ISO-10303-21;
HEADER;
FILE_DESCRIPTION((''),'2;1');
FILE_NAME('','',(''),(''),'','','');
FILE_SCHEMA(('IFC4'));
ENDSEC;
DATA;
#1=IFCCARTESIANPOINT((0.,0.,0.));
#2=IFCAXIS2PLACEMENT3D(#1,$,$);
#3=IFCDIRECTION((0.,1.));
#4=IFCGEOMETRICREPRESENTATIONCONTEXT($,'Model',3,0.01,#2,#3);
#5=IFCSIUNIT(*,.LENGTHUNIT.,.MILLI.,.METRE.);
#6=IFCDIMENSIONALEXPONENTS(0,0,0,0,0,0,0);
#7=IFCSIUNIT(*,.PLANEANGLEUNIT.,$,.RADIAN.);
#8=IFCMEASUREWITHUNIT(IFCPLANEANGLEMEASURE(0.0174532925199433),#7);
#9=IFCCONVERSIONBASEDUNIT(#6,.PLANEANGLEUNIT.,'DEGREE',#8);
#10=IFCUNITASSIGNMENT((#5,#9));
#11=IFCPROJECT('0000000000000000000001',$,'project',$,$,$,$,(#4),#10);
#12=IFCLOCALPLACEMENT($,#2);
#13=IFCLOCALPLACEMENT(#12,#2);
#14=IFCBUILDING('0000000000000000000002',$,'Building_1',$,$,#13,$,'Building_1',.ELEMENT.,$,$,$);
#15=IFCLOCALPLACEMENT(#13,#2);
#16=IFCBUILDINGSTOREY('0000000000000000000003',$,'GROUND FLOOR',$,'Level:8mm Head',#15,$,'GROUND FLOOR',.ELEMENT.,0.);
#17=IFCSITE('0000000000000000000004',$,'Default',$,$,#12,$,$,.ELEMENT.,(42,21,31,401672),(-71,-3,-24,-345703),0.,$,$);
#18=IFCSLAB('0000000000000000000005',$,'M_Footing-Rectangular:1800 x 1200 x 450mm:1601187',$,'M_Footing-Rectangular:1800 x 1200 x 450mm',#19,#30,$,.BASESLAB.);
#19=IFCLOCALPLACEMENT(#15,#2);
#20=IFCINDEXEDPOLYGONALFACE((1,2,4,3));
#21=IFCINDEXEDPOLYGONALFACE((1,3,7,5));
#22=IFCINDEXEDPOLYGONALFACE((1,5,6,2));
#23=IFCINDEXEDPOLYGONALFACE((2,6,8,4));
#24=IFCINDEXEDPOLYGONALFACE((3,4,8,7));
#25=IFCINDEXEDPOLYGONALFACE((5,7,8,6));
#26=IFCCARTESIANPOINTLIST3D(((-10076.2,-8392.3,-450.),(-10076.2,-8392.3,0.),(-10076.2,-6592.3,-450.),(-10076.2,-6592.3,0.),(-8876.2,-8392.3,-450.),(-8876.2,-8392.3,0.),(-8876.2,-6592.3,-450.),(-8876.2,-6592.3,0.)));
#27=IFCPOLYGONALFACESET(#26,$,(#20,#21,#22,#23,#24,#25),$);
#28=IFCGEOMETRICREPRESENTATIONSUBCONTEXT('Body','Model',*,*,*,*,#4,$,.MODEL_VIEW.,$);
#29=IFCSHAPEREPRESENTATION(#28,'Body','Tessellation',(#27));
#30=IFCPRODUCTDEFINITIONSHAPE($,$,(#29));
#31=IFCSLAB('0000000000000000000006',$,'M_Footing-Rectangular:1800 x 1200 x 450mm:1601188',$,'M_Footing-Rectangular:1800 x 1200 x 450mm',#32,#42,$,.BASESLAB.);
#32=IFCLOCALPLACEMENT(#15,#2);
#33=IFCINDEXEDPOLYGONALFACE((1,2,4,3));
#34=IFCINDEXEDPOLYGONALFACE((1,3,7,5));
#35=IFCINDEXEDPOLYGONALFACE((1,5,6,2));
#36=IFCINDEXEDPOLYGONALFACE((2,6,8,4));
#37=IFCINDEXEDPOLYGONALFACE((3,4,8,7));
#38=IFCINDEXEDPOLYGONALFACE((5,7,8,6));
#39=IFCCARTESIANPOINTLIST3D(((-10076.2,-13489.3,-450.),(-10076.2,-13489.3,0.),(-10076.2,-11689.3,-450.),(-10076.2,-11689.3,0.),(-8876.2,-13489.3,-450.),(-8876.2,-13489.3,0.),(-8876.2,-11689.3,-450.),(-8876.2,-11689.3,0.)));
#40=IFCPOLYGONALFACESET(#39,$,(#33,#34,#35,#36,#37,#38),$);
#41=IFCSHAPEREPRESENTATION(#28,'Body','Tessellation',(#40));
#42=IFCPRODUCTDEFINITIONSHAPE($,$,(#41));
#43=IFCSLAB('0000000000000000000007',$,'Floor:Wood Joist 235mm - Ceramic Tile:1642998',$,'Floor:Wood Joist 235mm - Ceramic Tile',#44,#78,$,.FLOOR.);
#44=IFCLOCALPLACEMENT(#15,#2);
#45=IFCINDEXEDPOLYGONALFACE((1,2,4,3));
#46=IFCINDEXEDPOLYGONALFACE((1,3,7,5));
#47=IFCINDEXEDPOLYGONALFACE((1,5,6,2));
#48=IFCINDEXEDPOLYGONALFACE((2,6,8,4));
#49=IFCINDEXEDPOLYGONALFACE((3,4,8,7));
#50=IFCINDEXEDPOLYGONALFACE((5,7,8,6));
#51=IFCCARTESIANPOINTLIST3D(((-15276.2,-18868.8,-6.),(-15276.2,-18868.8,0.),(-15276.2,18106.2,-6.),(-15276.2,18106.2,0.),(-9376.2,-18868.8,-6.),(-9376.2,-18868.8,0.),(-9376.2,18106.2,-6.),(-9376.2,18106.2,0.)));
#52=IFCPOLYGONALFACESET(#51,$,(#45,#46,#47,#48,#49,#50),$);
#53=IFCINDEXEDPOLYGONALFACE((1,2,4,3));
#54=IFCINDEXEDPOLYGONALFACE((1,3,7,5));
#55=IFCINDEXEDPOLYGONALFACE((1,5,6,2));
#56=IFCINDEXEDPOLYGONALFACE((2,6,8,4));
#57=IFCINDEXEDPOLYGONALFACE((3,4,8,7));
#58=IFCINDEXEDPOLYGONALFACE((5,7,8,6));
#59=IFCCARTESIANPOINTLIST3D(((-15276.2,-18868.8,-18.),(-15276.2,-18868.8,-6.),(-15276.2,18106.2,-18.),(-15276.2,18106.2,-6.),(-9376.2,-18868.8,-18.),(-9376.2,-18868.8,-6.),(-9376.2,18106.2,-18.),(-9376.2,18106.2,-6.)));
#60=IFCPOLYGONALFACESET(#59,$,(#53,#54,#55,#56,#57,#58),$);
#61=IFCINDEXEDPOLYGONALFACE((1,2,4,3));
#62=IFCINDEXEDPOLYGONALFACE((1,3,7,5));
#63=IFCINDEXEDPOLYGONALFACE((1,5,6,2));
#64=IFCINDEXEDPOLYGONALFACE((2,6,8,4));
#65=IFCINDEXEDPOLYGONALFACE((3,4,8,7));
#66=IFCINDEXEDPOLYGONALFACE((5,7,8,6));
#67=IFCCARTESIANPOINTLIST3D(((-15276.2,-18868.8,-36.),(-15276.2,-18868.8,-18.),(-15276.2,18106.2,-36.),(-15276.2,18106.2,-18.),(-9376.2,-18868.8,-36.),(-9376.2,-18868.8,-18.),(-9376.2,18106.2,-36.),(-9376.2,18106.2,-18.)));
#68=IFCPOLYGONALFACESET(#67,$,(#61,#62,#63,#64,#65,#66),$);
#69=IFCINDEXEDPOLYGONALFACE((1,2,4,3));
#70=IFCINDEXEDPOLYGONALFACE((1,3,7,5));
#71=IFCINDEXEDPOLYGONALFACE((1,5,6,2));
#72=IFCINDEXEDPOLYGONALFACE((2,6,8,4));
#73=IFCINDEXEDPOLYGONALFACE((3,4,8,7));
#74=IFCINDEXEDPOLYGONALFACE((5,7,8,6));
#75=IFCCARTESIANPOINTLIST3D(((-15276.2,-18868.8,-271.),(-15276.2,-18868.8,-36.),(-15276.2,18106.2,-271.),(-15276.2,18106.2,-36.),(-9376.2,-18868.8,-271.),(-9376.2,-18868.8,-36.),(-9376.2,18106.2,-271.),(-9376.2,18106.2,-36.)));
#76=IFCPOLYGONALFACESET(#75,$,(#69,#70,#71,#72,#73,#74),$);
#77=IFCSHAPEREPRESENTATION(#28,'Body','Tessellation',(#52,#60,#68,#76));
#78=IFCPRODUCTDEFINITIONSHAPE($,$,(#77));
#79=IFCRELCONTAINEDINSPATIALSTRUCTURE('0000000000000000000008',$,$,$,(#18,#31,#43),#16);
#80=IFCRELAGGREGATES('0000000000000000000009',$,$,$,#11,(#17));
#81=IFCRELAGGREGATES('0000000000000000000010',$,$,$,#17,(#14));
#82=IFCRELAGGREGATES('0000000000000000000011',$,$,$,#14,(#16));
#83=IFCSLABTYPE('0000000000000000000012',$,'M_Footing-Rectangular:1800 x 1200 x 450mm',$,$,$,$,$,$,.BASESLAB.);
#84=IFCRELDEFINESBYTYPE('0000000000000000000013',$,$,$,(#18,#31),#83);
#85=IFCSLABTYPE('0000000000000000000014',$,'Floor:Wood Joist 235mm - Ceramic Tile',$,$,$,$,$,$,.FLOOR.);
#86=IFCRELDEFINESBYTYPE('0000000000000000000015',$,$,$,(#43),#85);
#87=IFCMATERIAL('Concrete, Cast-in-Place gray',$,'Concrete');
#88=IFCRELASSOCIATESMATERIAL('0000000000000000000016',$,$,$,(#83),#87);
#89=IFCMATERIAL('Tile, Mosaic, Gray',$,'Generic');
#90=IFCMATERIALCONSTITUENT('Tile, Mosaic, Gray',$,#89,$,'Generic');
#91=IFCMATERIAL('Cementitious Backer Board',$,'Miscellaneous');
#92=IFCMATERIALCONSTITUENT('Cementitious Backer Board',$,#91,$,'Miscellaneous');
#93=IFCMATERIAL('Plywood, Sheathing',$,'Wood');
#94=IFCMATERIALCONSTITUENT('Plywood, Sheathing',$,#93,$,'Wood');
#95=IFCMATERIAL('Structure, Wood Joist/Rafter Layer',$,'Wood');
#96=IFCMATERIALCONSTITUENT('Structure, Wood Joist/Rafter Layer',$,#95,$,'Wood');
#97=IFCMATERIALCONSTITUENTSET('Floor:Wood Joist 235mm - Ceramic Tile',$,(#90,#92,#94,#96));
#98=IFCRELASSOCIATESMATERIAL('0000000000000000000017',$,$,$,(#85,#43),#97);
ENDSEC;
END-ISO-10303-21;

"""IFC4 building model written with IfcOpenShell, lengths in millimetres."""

from ifc_helpers import new_model, entity, si_unit, converted_unit, direction, frame, origin, place, context, subcontext, project, spatial, indexed_curve, outline, extrude, material, constituent, constituent_set, type_object, element, save


model = new_model("IFC4")

# Units and contexts
model_context = context("Model", 3, precision=0.01, world=origin(), true_north=direction((0.0, 1.0)))
body_context = subcontext(model_context, "Body", "Model", "MODEL_VIEW")
ifc_project = project(units=[si_unit("LENGTHUNIT", "METRE", prefix="MILLI"), converted_unit("PLANEANGLEUNIT", "DEGREE", entity("IfcPlaneAngleMeasure", 0.0174532925199433), si_unit("PLANEANGLEUNIT", "RADIAN"), dimensions=[0, 0, 0, 0, 0, 0, 0])], contexts=[model_context])

# Site, building, storey
site_placement = place(None, origin())
site = spatial("IfcSite", under=ifc_project, at=site_placement, Name="Default", CompositionType="ELEMENT", RefLatitude=(42, 21, 31, 401672), RefLongitude=(-71, -3, -24, -345703), RefElevation=0.0)
building_placement = place(site_placement, origin())
building = spatial("IfcBuilding", under=site, at=building_placement, Name="Building_1", LongName="Building_1", CompositionType="ELEMENT")
storey_placement = place(building_placement, origin())
storey = spatial("IfcBuildingStorey", under=building, at=storey_placement, Name="GROUND FLOOR", ObjectType="Level:8mm Head", LongName="GROUND FLOOR", CompositionType="ELEMENT", Elevation=0.0)

# Shared definitions
ifc_material_1 = material(Name="Concrete, Cast-in-Place gray", Category="Concrete")

# Slabs
slab_type_1 = type_object("IfcSlabType", Name="M_Footing-Rectangular:1800 x 1200 x 450mm", PredefinedType="BASESLAB", material=ifc_material_1)
slab_1_placement = place(storey_placement, origin())
element("IfcSlab", 1, at=slab_1_placement, inside=storey, type_object=slab_type_1, Name="M_Footing-Rectangular:1800 x 1200 x 450mm:1601187", ObjectType="M_Footing-Rectangular:1800 x 1200 x 450mm", PredefinedType="BASESLAB", context=body_context, shape_type="SweptSolid", body=[
    extrude(outline(indexed_curve([(-600.0, -900.0), (600.0, -900.0), (600.0, 900.0), (-600.0, 900.0), (-600.0, -900.0)], self_intersect=False)), frame((-9476.2, -7492.3, -450.0), z_axis=(0.0, 0.0, 1.0), x_axis=(-1.0, 0.0, 0.0)), (0.0, 0.0, 1.0), 450.0),
])
slab_2_placement = place(storey_placement, origin())
element("IfcSlab", 2, at=slab_2_placement, inside=storey, type_object=slab_type_1, Name="M_Footing-Rectangular:1800 x 1200 x 450mm:1601188", ObjectType="M_Footing-Rectangular:1800 x 1200 x 450mm", PredefinedType="BASESLAB", context=body_context, shape_type="SweptSolid", body=[
    extrude(outline(indexed_curve([(-600.0, -900.0), (600.0, -900.0), (600.0, 900.0), (-600.0, 900.0), (-600.0, -900.0)], self_intersect=False)), frame((-9476.2, -12589.3, -450.0), z_axis=(0.0, 0.0, 1.0), x_axis=(-1.0, 0.0, 0.0)), (0.0, 0.0, 1.0), 450.0),
])
ifc_material_2 = material(Name="Tile, Mosaic, Gray", Category="Generic")
ifc_constituent_1 = constituent(ifc_material_2, Name="Tile, Mosaic, Gray", Category="Generic")
ifc_material_3 = material(Name="Cementitious Backer Board", Category="Miscellaneous")
ifc_constituent_2 = constituent(ifc_material_3, Name="Cementitious Backer Board", Category="Miscellaneous")
ifc_material_4 = material(Name="Plywood, Sheathing", Category="Wood")
ifc_constituent_3 = constituent(ifc_material_4, Name="Plywood, Sheathing", Category="Wood")
ifc_material_5 = material(Name="Structure, Wood Joist/Rafter Layer", Category="Wood")
ifc_constituent_4 = constituent(ifc_material_5, Name="Structure, Wood Joist/Rafter Layer", Category="Wood")
ifc_constituent_set = constituent_set(constituents=[ifc_constituent_1, ifc_constituent_2, ifc_constituent_3, ifc_constituent_4], Name="Floor:Wood Joist 235mm - Ceramic Tile")
slab_type_2 = type_object("IfcSlabType", Name="Floor:Wood Joist 235mm - Ceramic Tile", PredefinedType="FLOOR", material=ifc_constituent_set)
slab_3_placement = place(storey_placement, origin())
element("IfcSlab", 3, at=slab_3_placement, inside=storey, type_object=slab_type_2, material=ifc_constituent_set, Name="Floor:Wood Joist 235mm - Ceramic Tile:1642998", ObjectType="Floor:Wood Joist 235mm - Ceramic Tile", PredefinedType="FLOOR", context=body_context, shape_type="SweptSolid", body=[
    extrude(outline(indexed_curve([(-2950.0, -18487.5), (2950.0, -18487.5), (2950.0, 18487.5), (-2950.0, 18487.5), (-2950.0, -18487.5)], self_intersect=False)), frame((-12326.2, -381.3, -6.0), z_axis=(0.0, 0.0, 1.0), x_axis=(-1.0, 0.0, 0.0)), (0.0, 0.0, 1.0), 6.0),
    extrude(outline(indexed_curve([(-2950.0, -18487.5), (2950.0, -18487.5), (2950.0, 18487.5), (-2950.0, 18487.5), (-2950.0, -18487.5)], self_intersect=False)), frame((-12326.2, -381.3, -18.0), z_axis=(0.0, 0.0, 1.0), x_axis=(-1.0, 0.0, 0.0)), (0.0, 0.0, 1.0), 12.0),
    extrude(outline(indexed_curve([(-2950.0, -18487.5), (2950.0, -18487.5), (2950.0, 18487.5), (-2950.0, 18487.5), (-2950.0, -18487.5)], self_intersect=False)), frame((-12326.2, -381.3, -36.0), z_axis=(0.0, 0.0, 1.0), x_axis=(-1.0, 0.0, 0.0)), (0.0, 0.0, 1.0), 18.0),
    extrude(outline(indexed_curve([(-2950.0, -18487.5), (2950.0, -18487.5), (2950.0, 18487.5), (-2950.0, 18487.5), (-2950.0, -18487.5)], self_intersect=False)), frame((-12326.2, -381.3, -271.0), z_axis=(0.0, 0.0, 1.0), x_axis=(-1.0, 0.0, 0.0)), (0.0, 0.0, 1.0), 235.0),
])

save(model, "model.ifc")
